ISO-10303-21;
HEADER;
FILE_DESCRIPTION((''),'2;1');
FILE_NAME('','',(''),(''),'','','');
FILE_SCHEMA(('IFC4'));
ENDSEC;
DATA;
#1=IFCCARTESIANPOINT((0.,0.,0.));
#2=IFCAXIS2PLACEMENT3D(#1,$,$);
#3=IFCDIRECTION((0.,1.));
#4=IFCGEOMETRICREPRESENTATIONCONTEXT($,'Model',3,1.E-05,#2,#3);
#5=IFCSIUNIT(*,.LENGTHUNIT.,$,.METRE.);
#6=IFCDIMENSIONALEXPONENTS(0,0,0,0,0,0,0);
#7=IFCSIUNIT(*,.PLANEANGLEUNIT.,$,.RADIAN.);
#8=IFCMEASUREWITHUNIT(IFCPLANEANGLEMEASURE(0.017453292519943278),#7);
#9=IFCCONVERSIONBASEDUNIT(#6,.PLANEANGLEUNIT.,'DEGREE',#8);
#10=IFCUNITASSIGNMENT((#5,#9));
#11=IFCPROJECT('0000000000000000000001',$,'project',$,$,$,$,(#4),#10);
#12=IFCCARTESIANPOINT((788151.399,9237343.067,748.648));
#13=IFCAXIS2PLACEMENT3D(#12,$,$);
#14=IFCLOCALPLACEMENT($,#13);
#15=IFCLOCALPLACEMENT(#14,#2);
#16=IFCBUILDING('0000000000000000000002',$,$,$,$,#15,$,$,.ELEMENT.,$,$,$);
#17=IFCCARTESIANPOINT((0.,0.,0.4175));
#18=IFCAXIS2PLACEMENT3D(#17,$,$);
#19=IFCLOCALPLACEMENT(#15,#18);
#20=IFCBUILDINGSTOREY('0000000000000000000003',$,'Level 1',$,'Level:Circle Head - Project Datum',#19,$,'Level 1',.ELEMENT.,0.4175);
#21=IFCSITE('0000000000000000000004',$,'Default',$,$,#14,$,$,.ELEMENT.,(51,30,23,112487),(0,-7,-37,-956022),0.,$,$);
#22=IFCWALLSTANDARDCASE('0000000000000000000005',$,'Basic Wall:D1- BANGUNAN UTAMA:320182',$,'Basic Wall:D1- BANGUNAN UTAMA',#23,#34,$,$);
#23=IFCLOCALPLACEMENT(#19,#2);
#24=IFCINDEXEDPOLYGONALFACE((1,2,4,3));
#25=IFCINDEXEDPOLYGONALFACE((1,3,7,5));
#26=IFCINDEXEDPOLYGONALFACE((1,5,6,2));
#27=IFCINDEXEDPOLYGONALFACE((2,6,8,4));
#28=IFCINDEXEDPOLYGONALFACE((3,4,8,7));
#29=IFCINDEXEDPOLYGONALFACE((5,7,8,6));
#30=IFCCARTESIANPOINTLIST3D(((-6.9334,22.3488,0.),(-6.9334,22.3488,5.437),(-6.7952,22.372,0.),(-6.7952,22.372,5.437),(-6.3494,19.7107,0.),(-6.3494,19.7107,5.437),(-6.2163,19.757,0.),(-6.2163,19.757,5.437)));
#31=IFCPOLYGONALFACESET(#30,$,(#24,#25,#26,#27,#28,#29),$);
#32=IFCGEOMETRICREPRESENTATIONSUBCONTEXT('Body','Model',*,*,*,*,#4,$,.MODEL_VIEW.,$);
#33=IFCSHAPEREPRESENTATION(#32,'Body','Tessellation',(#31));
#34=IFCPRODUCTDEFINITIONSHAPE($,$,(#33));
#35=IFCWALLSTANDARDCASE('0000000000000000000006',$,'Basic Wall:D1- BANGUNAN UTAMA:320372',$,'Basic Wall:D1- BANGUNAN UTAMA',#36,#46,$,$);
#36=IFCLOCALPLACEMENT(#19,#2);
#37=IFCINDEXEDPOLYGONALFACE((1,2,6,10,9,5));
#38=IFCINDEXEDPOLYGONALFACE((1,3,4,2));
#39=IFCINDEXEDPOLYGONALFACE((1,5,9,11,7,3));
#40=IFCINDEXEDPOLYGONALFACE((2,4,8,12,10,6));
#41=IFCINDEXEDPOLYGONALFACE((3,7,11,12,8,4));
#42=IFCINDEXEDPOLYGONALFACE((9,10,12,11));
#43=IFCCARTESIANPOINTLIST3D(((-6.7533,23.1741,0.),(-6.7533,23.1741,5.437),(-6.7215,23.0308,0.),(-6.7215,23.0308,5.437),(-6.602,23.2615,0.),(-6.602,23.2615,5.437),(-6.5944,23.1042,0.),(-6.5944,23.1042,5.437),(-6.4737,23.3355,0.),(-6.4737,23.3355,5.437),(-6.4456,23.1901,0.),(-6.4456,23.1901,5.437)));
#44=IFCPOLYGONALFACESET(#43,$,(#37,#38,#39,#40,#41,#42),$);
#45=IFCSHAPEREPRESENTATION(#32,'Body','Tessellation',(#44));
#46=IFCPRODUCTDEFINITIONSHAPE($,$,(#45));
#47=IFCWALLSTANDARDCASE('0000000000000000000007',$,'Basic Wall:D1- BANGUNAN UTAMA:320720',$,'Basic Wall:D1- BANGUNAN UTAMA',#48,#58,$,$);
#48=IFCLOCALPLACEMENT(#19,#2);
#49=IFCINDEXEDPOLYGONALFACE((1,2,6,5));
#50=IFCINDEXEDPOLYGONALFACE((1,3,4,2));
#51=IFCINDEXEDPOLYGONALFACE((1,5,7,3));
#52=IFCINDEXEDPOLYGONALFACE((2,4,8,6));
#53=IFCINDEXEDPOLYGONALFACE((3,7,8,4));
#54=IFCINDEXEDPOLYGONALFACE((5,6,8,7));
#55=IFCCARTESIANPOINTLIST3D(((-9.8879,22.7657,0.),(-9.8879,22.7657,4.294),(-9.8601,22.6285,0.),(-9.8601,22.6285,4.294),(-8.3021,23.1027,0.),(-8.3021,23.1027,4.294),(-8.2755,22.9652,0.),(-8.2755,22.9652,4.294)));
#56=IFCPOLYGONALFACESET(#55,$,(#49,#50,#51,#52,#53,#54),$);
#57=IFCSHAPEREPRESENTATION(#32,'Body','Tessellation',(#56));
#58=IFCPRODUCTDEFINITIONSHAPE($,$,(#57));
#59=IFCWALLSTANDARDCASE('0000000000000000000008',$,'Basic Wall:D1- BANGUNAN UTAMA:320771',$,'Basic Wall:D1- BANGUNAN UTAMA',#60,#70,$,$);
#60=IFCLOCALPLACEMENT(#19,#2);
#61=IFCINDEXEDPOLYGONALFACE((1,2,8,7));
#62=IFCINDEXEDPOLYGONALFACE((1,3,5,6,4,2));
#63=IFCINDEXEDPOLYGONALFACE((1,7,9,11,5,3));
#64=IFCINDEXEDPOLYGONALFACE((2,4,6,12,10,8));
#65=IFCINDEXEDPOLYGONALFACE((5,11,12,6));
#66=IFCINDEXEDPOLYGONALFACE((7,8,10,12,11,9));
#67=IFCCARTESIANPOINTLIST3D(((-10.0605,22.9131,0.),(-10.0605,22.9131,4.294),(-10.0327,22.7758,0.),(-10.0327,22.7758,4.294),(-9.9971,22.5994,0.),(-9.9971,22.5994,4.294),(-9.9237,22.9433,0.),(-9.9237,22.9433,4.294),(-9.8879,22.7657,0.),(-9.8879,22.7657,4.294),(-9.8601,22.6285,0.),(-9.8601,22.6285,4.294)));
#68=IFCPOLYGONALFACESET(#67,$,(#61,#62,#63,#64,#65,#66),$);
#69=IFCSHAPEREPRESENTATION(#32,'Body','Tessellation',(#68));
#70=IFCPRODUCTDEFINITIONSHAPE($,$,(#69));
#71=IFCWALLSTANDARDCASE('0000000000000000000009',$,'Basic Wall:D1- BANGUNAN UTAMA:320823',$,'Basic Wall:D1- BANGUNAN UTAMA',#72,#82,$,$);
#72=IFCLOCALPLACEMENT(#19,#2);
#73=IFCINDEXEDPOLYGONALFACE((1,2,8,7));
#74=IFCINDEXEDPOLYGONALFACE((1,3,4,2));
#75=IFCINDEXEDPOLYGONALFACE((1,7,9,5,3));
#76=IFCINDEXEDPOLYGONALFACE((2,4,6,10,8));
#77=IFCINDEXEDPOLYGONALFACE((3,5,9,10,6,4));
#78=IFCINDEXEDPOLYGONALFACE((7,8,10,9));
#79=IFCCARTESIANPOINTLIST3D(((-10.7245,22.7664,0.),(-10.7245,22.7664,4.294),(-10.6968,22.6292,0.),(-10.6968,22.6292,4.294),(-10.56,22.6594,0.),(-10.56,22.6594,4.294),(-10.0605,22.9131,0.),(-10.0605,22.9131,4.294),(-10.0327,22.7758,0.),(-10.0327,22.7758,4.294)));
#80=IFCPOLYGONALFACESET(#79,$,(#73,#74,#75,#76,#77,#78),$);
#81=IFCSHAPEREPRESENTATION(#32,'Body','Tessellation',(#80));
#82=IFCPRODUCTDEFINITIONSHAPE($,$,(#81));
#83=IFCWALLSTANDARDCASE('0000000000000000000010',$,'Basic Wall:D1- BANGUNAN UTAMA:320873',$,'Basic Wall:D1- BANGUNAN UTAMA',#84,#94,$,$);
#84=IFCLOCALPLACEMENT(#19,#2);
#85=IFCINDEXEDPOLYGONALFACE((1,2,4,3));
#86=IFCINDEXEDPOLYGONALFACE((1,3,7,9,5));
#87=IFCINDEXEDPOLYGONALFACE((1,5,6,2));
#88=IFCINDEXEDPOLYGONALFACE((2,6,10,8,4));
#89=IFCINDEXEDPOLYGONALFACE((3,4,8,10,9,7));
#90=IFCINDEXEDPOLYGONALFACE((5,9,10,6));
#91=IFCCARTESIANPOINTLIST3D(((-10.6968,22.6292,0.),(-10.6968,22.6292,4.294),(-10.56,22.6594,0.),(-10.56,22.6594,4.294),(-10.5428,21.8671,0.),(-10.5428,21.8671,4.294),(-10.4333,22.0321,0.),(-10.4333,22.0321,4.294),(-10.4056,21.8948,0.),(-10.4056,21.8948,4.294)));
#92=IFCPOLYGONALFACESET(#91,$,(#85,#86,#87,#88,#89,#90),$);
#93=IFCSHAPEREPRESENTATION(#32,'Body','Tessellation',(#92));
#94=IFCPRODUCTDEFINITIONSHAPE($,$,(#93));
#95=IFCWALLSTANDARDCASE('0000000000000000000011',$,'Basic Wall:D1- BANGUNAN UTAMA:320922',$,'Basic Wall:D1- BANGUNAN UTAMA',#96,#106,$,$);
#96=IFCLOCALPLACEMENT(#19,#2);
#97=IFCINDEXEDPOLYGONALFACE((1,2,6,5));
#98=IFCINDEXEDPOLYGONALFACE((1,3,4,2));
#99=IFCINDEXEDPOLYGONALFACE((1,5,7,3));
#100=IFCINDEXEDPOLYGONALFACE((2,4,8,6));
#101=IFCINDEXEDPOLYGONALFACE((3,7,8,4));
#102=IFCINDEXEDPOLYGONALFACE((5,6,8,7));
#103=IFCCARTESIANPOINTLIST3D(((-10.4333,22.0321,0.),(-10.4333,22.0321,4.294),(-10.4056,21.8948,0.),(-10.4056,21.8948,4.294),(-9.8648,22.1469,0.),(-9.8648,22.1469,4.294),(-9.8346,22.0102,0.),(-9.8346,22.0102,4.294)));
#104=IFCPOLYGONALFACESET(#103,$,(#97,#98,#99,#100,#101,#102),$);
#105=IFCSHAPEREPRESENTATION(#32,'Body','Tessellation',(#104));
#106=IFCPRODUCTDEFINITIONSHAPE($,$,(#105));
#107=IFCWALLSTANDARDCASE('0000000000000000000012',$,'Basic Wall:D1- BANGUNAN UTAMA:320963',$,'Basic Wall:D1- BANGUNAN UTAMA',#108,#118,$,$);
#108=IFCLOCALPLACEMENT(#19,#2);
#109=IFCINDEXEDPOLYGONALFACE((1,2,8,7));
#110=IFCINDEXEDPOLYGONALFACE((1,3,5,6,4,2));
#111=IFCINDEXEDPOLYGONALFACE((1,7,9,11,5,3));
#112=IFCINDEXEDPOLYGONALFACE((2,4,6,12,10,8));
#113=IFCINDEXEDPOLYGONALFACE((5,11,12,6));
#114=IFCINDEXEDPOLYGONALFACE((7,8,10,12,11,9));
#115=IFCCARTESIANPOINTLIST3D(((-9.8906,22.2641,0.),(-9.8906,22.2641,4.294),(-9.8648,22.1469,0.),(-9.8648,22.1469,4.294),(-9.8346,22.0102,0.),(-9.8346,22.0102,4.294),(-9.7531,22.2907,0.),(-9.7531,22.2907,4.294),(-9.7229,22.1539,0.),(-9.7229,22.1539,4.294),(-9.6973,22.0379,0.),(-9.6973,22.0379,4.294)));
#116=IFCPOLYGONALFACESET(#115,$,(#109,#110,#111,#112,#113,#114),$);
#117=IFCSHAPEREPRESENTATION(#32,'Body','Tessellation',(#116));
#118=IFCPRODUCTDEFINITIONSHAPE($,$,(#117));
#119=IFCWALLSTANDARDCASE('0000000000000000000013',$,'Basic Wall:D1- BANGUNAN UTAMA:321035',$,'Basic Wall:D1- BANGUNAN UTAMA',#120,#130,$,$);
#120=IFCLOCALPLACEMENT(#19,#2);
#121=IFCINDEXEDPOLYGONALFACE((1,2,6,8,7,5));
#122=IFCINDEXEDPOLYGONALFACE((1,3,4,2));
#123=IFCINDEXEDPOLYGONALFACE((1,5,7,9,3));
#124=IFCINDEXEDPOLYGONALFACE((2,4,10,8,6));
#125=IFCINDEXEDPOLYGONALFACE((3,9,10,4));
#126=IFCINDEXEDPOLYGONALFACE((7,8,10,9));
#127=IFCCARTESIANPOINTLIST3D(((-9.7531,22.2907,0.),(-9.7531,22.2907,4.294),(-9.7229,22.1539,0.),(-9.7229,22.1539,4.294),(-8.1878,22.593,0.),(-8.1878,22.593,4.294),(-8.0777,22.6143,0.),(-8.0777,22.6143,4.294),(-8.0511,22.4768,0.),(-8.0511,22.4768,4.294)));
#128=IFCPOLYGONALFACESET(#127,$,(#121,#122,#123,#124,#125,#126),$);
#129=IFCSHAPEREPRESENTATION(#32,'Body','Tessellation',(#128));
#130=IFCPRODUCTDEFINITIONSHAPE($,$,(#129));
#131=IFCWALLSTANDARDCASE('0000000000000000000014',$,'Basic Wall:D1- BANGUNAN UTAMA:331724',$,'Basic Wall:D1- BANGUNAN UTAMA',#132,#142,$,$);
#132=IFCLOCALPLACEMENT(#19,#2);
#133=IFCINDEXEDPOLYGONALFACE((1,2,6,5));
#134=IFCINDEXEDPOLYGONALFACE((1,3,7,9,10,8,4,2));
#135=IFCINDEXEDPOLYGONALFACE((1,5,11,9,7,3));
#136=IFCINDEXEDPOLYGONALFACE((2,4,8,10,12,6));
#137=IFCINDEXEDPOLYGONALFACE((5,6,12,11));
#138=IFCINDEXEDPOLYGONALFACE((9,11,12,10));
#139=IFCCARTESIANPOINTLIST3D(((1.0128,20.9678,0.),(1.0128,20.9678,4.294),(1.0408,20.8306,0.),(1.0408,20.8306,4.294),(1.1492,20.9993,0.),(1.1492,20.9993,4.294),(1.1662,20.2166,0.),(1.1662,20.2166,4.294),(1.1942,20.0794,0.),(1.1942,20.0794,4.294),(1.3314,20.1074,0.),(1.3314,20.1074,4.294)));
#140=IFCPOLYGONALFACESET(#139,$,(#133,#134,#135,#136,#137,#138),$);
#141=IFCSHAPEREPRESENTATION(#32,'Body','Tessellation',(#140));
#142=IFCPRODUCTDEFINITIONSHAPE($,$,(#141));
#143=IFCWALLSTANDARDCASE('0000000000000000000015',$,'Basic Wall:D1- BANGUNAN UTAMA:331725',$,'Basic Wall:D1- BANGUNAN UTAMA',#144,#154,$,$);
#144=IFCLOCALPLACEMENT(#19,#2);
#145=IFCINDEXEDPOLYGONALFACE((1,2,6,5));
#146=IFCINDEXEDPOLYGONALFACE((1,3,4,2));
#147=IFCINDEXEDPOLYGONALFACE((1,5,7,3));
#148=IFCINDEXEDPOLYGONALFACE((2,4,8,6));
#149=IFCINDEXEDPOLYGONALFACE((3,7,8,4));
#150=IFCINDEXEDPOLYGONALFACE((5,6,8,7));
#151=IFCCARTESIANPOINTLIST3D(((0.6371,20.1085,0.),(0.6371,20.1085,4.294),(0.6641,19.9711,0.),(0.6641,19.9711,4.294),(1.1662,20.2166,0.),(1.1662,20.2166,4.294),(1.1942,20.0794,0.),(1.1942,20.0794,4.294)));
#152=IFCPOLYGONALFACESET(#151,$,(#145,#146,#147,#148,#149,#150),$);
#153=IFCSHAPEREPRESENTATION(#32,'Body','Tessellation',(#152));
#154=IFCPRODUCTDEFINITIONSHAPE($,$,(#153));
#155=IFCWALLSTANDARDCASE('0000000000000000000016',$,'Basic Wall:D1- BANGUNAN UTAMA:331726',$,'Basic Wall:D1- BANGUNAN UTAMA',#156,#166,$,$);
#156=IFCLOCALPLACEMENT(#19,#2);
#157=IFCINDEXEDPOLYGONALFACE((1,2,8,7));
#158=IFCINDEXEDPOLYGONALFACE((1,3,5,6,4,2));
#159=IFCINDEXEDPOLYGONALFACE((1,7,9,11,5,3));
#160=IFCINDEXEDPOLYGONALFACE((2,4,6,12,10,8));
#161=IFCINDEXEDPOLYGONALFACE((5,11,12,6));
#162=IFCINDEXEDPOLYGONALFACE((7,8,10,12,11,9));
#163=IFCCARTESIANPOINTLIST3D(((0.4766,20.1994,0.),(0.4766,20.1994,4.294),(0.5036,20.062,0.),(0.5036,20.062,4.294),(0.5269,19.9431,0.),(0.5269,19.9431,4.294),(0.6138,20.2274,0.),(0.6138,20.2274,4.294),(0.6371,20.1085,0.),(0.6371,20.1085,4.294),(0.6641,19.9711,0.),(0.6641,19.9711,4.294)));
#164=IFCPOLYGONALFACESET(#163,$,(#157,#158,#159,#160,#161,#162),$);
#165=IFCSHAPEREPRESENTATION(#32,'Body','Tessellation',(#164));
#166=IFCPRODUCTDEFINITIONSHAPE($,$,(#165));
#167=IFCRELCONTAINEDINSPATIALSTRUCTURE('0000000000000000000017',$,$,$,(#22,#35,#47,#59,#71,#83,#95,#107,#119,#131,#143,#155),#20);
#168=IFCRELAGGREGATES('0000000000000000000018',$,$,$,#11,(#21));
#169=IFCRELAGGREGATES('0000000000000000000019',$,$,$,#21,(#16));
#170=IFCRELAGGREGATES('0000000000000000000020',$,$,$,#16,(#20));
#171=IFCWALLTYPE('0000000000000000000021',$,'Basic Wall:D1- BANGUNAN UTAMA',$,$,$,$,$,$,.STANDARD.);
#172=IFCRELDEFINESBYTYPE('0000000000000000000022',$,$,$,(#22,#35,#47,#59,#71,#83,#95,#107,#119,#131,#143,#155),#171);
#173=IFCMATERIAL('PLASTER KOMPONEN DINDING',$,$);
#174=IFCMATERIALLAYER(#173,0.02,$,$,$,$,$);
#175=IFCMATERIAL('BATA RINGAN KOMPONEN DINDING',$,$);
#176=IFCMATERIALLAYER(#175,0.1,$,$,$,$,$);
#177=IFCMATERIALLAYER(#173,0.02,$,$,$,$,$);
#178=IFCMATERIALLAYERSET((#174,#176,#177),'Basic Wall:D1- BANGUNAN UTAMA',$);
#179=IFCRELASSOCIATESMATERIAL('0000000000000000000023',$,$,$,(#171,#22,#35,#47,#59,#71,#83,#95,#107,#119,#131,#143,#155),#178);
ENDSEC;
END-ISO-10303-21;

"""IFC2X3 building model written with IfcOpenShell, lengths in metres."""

from ifc_helpers import new_model, entity, si_unit, converted_unit, direction, frame, origin, place, context, subcontext, project, spatial, polyline, outline, extrude, material, layer, layer_set, layer_usage, type_object, element, save


model = new_model("IFC2X3")

# Units and contexts
model_context = context("Model", 3, precision=1e-05, world=origin(), true_north=direction((0.0, 1.0)))
body_context = subcontext(model_context, "Body", "Model", "MODEL_VIEW")
ifc_project = project(units=[si_unit("LENGTHUNIT", "METRE"), converted_unit("PLANEANGLEUNIT", "DEGREE", entity("IfcPlaneAngleMeasure", 0.017453292519943278), si_unit("PLANEANGLEUNIT", "RADIAN"), dimensions=[0, 0, 0, 0, 0, 0, 0])], contexts=[model_context])

# Site, building, storey
site_placement = place(None, frame((788151.399, 9237343.067, 748.648)))
site = spatial("IfcSite", under=ifc_project, at=site_placement, Name="Default", CompositionType="ELEMENT", RefLatitude=(51, 30, 23, 112487), RefLongitude=(0, -7, -37, -956022), RefElevation=0.0)
building_placement = place(site_placement, origin())
building = spatial("IfcBuilding", under=site, at=building_placement, CompositionType="ELEMENT")
storey_placement = place(building_placement, frame((0.0, 0.0, 0.4175)))
storey = spatial("IfcBuildingStorey", under=building, at=storey_placement, Name="Level 1", ObjectType="Level:Circle Head - Project Datum", LongName="Level 1", CompositionType="ELEMENT", Elevation=0.4175)

# Walls
ifc_material_1 = material(Name="PLASTER KOMPONEN DINDING")
ifc_layer_1 = layer(ifc_material_1, 0.02)
ifc_material_2 = material(Name="BATA RINGAN KOMPONEN DINDING")
ifc_layer_2 = layer(ifc_material_2, 0.1)
ifc_layer_3 = layer(ifc_material_1, 0.02)
ifc_layer_set = layer_set([ifc_layer_1, ifc_layer_2, ifc_layer_3], Name="Basic Wall:D1- BANGUNAN UTAMA")
wall_type = type_object("IfcWallType", Name="Basic Wall:D1- BANGUNAN UTAMA", PredefinedType="STANDARD", material=ifc_layer_set)
ifc_layer_usage_1 = layer_usage(ifc_layer_set, "AXIS2", "NEGATIVE", 0.07)
wall_1_placement = place(storey_placement, frame((-6.2811, 19.7258, 0.0), z_axis=(0.0, 0.0, 1.0), x_axis=(-0.21615, 0.97636, 0.0)))
element("IfcWallStandardCase", 1, at=wall_1_placement, inside=storey, type_object=wall_type, material=ifc_layer_usage_1, Name="Basic Wall:D1- BANGUNAN UTAMA:320182", ObjectType="Basic Wall:D1- BANGUNAN UTAMA", context=body_context, shape_type="SweptSolid", body=[
    extrude(outline(polyline([(2.6948, -0.07), (2.702, 0.07), (0.0, 0.07), (0.0164, -0.07), (2.6948, -0.07)])), origin(), (0.0, 0.0, 1.0), 5.437),
])
ifc_layer_usage_2 = layer_usage(ifc_layer_set, "AXIS2", "NEGATIVE", 0.07)
wall_2_placement = place(storey_placement, frame((-6.7565, 23.0914, 0.0), z_axis=(0.0, 0.0, 1.0), x_axis=(0.866025, 0.5, 0.0)))
element("IfcWallStandardCase", 2, at=wall_2_placement, inside=storey, type_object=wall_type, material=ifc_layer_usage_2, Name="Basic Wall:D1- BANGUNAN UTAMA:320372", ObjectType="Basic Wall:D1- BANGUNAN UTAMA", context=body_context, shape_type="SweptSolid", body=[
    extrude(outline(polyline([(0.3187, -0.07), (0.3671, 0.07), (0.2189, 0.07), (0.0442, 0.07), (0.0, -0.07), (0.1468, -0.07), (0.3187, -0.07)])), origin(), (0.0, 0.0, 1.0), 5.437),
])
ifc_layer_usage_3 = layer_usage(ifc_layer_set, "AXIS2", "NEGATIVE", 0.07)
wall_3_placement = place(storey_placement, frame((-8.2875, 23.0342, 0.0), z_axis=(0.0, 0.0, 1.0), x_axis=(-0.978158, -0.207863, 0.0)))
element("IfcWallStandardCase", 3, at=wall_3_placement, inside=storey, type_object=wall_type, material=ifc_layer_usage_3, Name="Basic Wall:D1- BANGUNAN UTAMA:320720", ObjectType="Basic Wall:D1- BANGUNAN UTAMA", context=body_context, shape_type="SweptSolid", body=[
    extrude(outline(polyline([(1.6212, -0.07), (1.6226, 0.07), (0.0026, 0.07), (0.0, -0.07), (1.6212, -0.07)])), origin(), (0.0, 0.0, 1.0), 4.294),
])
ifc_layer_usage_4 = layer_usage(ifc_layer_set, "AXIS2", "NEGATIVE", 0.07)
wall_4_placement = place(storey_placement, frame((-9.9285, 22.6132, 0.0), z_axis=(0.0, 0.0, 1.0), x_axis=(-0.198028, 0.980196, 0.0)))
element("IfcWallStandardCase", 4, at=wall_4_placement, inside=storey, type_object=wall_type, material=ifc_layer_usage_4, Name="Basic Wall:D1- BANGUNAN UTAMA:320771", ObjectType="Basic Wall:D1- BANGUNAN UTAMA", context=body_context, shape_type="SweptSolid", body=[
    extrude(outline(polyline([(0.3225, -0.07), (0.32, 0.07), (0.18, 0.07), (0.0, 0.07), (0.0014, -0.07), (0.1414, -0.07), (0.3225, -0.07)])), origin(), (0.0, 0.0, 1.0), 4.294),
])
ifc_layer_usage_5 = layer_usage(ifc_layer_set, "AXIS2", "NEGATIVE", 0.07)
wall_5_placement = place(storey_placement, frame((-10.0454, 22.8447, 0.0), z_axis=(0.0, 0.0, 1.0), x_axis=(-0.976481, -0.215604, 0.0)))
element("IfcWallStandardCase", 5, at=wall_5_placement, inside=storey, type_object=wall_type, material=ifc_layer_usage_5, Name="Basic Wall:D1- BANGUNAN UTAMA:320823", ObjectType="Basic Wall:D1- BANGUNAN UTAMA", context=body_context, shape_type="SweptSolid", body=[
    extrude(outline(polyline([(0.68, -0.07), (0.6825, 0.07), (0.5425, 0.07), (0.0025, 0.07), (0.0, -0.07), (0.68, -0.07)])), origin(), (0.0, 0.0, 1.0), 4.294),
])
ifc_layer_usage_6 = layer_usage(ifc_layer_set, "AXIS2", "NEGATIVE", 0.07)
wall_6_placement = place(storey_placement, frame((-10.6286, 22.6455, 0.0), z_axis=(0.0, 0.0, 1.0), x_axis=(0.198028, -0.980196, 0.0)))
element("IfcWallStandardCase", 6, at=wall_6_placement, inside=storey, type_object=wall_type, material=ifc_layer_usage_6, Name="Basic Wall:D1- BANGUNAN UTAMA:320873", ObjectType="Basic Wall:D1- BANGUNAN UTAMA", context=body_context, shape_type="SweptSolid", body=[
    extrude(outline(polyline([(0.78, -0.07), (0.78, 0.07), (0.64, 0.07), (0.0, 0.07), (0.0025, -0.07), (0.78, -0.07)])), origin(), (0.0, 0.0, 1.0), 4.294),
])
ifc_layer_usage_7 = layer_usage(ifc_layer_set, "AXIS2", "NEGATIVE", 0.07)
wall_7_placement = place(storey_placement, frame((-10.4194, 21.9634, 0.0), z_axis=(0.0, 0.0, 1.0), x_axis=(0.980196, 0.198028, 0.0)))
element("IfcWallStandardCase", 7, at=wall_7_placement, inside=storey, type_object=wall_type, material=ifc_layer_usage_7, Name="Basic Wall:D1- BANGUNAN UTAMA:320922", ObjectType="Basic Wall:D1- BANGUNAN UTAMA", context=body_context, shape_type="SweptSolid", body=[
    extrude(outline(polyline([(0.5825, -0.07), (0.58, 0.07), (0.0, 0.07), (0.0, -0.07), (0.5825, -0.07)])), origin(), (0.0, 0.0, 1.0), 4.294),
])
ifc_layer_usage_8 = layer_usage(ifc_layer_set, "AXIS2", "NEGATIVE", 0.07)
wall_8_placement = place(storey_placement, frame((-9.7657, 22.0228, 0.0), z_axis=(0.0, 0.0, 1.0), x_axis=(-0.215604, 0.976481, 0.0)))
element("IfcWallStandardCase", 8, at=wall_8_placement, inside=storey, type_object=wall_type, material=ifc_layer_usage_8, Name="Basic Wall:D1- BANGUNAN UTAMA:320963", ObjectType="Basic Wall:D1- BANGUNAN UTAMA", context=body_context, shape_type="SweptSolid", body=[
    extrude(outline(polyline([(0.2588, -0.07), (0.2625, 0.07), (0.1425, 0.07), (0.0025, 0.07), (0.0, -0.07), (0.1188, -0.07), (0.2588, -0.07)])), origin(), (0.0, 0.0, 1.0), 4.294),
])
ifc_layer_usage_9 = layer_usage(ifc_layer_set, "AXIS2", "NEGATIVE", 0.07)
wall_9_placement = place(storey_placement, frame((-9.7399, 22.2219, 0.0), z_axis=(0.0, 0.0, 1.0), x_axis=(0.981853, 0.189641, 0.0)))
element("IfcWallStandardCase", 9, at=wall_9_placement, inside=storey, type_object=wall_type, material=ifc_layer_usage_9, Name="Basic Wall:D1- BANGUNAN UTAMA:321035", ObjectType="Basic Wall:D1- BANGUNAN UTAMA", context=body_context, shape_type="SweptSolid", body=[
    extrude(outline(polyline([(1.7064, -0.07), (1.7064, 0.07), (1.5943, 0.07), (0.0, 0.07), (0.0037, -0.07), (1.7064, -0.07)])), origin(), (0.0, 0.0, 1.0), 4.294),
])
ifc_layer_usage_10 = layer_usage(ifc_layer_set, "AXIS2", "POSITIVE", -0.07)
wall_10_placement = place(storey_placement, frame((1.0806, 20.9853, 0.0), z_axis=(0.0, 0.0, 1.0), x_axis=(0.200109, -0.979774, 0.0)))
element("IfcWallStandardCase", 10, at=wall_10_placement, inside=storey, type_object=wall_type, material=ifc_layer_usage_10, Name="Basic Wall:D1- BANGUNAN UTAMA:331724", ObjectType="Basic Wall:D1- BANGUNAN UTAMA", context=body_context, shape_type="SweptSolid", body=[
    extrude(outline(polyline([(0.9103, -0.07), (0.9103, 0.07), (0.0, 0.07), (0.0035, -0.07), (0.1436, -0.07), (0.7703, -0.07), (0.9103, -0.07)])), origin(), (0.0, 0.0, 1.0), 4.294),
])
ifc_layer_usage_11 = layer_usage(ifc_layer_set, "AXIS2", "POSITIVE", -0.07)
wall_11_placement = place(storey_placement, frame((1.1802, 20.148, 0.0), z_axis=(0.0, 0.0, 1.0), x_axis=(-0.979774, -0.200109, 0.0)))
element("IfcWallStandardCase", 11, at=wall_11_placement, inside=storey, type_object=wall_type, material=ifc_layer_usage_11, Name="Basic Wall:D1- BANGUNAN UTAMA:331725", ObjectType="Basic Wall:D1- BANGUNAN UTAMA", context=body_context, shape_type="SweptSolid", body=[
    extrude(outline(polyline([(0.54, -0.07), (0.541, 0.07), (0.0, 0.07), (0.0, -0.07), (0.54, -0.07)])), origin(), (0.0, 0.0, 1.0), 4.294),
])
ifc_layer_usage_12 = layer_usage(ifc_layer_set, "AXIS2", "POSITIVE", -0.07)
wall_12_placement = place(storey_placement, frame((0.5956, 19.9566, 0.0), z_axis=(0.0, 0.0, 1.0), x_axis=(-0.192762, 0.981245, 0.0)))
element("IfcWallStandardCase", 12, at=wall_12_placement, inside=storey, type_object=wall_type, material=ifc_layer_usage_12, Name="Basic Wall:D1- BANGUNAN UTAMA:331726", ObjectType="Basic Wall:D1- BANGUNAN UTAMA", context=body_context, shape_type="SweptSolid", body=[
    extrude(outline(polyline([(0.2622, -0.07), (0.2612, 0.07), (0.1212, 0.07), (0.0, 0.07), (0.001, -0.07), (0.1411, -0.07), (0.2622, -0.07)])), origin(), (0.0, 0.0, 1.0), 4.294),
])

save(model, "model.ifc")
